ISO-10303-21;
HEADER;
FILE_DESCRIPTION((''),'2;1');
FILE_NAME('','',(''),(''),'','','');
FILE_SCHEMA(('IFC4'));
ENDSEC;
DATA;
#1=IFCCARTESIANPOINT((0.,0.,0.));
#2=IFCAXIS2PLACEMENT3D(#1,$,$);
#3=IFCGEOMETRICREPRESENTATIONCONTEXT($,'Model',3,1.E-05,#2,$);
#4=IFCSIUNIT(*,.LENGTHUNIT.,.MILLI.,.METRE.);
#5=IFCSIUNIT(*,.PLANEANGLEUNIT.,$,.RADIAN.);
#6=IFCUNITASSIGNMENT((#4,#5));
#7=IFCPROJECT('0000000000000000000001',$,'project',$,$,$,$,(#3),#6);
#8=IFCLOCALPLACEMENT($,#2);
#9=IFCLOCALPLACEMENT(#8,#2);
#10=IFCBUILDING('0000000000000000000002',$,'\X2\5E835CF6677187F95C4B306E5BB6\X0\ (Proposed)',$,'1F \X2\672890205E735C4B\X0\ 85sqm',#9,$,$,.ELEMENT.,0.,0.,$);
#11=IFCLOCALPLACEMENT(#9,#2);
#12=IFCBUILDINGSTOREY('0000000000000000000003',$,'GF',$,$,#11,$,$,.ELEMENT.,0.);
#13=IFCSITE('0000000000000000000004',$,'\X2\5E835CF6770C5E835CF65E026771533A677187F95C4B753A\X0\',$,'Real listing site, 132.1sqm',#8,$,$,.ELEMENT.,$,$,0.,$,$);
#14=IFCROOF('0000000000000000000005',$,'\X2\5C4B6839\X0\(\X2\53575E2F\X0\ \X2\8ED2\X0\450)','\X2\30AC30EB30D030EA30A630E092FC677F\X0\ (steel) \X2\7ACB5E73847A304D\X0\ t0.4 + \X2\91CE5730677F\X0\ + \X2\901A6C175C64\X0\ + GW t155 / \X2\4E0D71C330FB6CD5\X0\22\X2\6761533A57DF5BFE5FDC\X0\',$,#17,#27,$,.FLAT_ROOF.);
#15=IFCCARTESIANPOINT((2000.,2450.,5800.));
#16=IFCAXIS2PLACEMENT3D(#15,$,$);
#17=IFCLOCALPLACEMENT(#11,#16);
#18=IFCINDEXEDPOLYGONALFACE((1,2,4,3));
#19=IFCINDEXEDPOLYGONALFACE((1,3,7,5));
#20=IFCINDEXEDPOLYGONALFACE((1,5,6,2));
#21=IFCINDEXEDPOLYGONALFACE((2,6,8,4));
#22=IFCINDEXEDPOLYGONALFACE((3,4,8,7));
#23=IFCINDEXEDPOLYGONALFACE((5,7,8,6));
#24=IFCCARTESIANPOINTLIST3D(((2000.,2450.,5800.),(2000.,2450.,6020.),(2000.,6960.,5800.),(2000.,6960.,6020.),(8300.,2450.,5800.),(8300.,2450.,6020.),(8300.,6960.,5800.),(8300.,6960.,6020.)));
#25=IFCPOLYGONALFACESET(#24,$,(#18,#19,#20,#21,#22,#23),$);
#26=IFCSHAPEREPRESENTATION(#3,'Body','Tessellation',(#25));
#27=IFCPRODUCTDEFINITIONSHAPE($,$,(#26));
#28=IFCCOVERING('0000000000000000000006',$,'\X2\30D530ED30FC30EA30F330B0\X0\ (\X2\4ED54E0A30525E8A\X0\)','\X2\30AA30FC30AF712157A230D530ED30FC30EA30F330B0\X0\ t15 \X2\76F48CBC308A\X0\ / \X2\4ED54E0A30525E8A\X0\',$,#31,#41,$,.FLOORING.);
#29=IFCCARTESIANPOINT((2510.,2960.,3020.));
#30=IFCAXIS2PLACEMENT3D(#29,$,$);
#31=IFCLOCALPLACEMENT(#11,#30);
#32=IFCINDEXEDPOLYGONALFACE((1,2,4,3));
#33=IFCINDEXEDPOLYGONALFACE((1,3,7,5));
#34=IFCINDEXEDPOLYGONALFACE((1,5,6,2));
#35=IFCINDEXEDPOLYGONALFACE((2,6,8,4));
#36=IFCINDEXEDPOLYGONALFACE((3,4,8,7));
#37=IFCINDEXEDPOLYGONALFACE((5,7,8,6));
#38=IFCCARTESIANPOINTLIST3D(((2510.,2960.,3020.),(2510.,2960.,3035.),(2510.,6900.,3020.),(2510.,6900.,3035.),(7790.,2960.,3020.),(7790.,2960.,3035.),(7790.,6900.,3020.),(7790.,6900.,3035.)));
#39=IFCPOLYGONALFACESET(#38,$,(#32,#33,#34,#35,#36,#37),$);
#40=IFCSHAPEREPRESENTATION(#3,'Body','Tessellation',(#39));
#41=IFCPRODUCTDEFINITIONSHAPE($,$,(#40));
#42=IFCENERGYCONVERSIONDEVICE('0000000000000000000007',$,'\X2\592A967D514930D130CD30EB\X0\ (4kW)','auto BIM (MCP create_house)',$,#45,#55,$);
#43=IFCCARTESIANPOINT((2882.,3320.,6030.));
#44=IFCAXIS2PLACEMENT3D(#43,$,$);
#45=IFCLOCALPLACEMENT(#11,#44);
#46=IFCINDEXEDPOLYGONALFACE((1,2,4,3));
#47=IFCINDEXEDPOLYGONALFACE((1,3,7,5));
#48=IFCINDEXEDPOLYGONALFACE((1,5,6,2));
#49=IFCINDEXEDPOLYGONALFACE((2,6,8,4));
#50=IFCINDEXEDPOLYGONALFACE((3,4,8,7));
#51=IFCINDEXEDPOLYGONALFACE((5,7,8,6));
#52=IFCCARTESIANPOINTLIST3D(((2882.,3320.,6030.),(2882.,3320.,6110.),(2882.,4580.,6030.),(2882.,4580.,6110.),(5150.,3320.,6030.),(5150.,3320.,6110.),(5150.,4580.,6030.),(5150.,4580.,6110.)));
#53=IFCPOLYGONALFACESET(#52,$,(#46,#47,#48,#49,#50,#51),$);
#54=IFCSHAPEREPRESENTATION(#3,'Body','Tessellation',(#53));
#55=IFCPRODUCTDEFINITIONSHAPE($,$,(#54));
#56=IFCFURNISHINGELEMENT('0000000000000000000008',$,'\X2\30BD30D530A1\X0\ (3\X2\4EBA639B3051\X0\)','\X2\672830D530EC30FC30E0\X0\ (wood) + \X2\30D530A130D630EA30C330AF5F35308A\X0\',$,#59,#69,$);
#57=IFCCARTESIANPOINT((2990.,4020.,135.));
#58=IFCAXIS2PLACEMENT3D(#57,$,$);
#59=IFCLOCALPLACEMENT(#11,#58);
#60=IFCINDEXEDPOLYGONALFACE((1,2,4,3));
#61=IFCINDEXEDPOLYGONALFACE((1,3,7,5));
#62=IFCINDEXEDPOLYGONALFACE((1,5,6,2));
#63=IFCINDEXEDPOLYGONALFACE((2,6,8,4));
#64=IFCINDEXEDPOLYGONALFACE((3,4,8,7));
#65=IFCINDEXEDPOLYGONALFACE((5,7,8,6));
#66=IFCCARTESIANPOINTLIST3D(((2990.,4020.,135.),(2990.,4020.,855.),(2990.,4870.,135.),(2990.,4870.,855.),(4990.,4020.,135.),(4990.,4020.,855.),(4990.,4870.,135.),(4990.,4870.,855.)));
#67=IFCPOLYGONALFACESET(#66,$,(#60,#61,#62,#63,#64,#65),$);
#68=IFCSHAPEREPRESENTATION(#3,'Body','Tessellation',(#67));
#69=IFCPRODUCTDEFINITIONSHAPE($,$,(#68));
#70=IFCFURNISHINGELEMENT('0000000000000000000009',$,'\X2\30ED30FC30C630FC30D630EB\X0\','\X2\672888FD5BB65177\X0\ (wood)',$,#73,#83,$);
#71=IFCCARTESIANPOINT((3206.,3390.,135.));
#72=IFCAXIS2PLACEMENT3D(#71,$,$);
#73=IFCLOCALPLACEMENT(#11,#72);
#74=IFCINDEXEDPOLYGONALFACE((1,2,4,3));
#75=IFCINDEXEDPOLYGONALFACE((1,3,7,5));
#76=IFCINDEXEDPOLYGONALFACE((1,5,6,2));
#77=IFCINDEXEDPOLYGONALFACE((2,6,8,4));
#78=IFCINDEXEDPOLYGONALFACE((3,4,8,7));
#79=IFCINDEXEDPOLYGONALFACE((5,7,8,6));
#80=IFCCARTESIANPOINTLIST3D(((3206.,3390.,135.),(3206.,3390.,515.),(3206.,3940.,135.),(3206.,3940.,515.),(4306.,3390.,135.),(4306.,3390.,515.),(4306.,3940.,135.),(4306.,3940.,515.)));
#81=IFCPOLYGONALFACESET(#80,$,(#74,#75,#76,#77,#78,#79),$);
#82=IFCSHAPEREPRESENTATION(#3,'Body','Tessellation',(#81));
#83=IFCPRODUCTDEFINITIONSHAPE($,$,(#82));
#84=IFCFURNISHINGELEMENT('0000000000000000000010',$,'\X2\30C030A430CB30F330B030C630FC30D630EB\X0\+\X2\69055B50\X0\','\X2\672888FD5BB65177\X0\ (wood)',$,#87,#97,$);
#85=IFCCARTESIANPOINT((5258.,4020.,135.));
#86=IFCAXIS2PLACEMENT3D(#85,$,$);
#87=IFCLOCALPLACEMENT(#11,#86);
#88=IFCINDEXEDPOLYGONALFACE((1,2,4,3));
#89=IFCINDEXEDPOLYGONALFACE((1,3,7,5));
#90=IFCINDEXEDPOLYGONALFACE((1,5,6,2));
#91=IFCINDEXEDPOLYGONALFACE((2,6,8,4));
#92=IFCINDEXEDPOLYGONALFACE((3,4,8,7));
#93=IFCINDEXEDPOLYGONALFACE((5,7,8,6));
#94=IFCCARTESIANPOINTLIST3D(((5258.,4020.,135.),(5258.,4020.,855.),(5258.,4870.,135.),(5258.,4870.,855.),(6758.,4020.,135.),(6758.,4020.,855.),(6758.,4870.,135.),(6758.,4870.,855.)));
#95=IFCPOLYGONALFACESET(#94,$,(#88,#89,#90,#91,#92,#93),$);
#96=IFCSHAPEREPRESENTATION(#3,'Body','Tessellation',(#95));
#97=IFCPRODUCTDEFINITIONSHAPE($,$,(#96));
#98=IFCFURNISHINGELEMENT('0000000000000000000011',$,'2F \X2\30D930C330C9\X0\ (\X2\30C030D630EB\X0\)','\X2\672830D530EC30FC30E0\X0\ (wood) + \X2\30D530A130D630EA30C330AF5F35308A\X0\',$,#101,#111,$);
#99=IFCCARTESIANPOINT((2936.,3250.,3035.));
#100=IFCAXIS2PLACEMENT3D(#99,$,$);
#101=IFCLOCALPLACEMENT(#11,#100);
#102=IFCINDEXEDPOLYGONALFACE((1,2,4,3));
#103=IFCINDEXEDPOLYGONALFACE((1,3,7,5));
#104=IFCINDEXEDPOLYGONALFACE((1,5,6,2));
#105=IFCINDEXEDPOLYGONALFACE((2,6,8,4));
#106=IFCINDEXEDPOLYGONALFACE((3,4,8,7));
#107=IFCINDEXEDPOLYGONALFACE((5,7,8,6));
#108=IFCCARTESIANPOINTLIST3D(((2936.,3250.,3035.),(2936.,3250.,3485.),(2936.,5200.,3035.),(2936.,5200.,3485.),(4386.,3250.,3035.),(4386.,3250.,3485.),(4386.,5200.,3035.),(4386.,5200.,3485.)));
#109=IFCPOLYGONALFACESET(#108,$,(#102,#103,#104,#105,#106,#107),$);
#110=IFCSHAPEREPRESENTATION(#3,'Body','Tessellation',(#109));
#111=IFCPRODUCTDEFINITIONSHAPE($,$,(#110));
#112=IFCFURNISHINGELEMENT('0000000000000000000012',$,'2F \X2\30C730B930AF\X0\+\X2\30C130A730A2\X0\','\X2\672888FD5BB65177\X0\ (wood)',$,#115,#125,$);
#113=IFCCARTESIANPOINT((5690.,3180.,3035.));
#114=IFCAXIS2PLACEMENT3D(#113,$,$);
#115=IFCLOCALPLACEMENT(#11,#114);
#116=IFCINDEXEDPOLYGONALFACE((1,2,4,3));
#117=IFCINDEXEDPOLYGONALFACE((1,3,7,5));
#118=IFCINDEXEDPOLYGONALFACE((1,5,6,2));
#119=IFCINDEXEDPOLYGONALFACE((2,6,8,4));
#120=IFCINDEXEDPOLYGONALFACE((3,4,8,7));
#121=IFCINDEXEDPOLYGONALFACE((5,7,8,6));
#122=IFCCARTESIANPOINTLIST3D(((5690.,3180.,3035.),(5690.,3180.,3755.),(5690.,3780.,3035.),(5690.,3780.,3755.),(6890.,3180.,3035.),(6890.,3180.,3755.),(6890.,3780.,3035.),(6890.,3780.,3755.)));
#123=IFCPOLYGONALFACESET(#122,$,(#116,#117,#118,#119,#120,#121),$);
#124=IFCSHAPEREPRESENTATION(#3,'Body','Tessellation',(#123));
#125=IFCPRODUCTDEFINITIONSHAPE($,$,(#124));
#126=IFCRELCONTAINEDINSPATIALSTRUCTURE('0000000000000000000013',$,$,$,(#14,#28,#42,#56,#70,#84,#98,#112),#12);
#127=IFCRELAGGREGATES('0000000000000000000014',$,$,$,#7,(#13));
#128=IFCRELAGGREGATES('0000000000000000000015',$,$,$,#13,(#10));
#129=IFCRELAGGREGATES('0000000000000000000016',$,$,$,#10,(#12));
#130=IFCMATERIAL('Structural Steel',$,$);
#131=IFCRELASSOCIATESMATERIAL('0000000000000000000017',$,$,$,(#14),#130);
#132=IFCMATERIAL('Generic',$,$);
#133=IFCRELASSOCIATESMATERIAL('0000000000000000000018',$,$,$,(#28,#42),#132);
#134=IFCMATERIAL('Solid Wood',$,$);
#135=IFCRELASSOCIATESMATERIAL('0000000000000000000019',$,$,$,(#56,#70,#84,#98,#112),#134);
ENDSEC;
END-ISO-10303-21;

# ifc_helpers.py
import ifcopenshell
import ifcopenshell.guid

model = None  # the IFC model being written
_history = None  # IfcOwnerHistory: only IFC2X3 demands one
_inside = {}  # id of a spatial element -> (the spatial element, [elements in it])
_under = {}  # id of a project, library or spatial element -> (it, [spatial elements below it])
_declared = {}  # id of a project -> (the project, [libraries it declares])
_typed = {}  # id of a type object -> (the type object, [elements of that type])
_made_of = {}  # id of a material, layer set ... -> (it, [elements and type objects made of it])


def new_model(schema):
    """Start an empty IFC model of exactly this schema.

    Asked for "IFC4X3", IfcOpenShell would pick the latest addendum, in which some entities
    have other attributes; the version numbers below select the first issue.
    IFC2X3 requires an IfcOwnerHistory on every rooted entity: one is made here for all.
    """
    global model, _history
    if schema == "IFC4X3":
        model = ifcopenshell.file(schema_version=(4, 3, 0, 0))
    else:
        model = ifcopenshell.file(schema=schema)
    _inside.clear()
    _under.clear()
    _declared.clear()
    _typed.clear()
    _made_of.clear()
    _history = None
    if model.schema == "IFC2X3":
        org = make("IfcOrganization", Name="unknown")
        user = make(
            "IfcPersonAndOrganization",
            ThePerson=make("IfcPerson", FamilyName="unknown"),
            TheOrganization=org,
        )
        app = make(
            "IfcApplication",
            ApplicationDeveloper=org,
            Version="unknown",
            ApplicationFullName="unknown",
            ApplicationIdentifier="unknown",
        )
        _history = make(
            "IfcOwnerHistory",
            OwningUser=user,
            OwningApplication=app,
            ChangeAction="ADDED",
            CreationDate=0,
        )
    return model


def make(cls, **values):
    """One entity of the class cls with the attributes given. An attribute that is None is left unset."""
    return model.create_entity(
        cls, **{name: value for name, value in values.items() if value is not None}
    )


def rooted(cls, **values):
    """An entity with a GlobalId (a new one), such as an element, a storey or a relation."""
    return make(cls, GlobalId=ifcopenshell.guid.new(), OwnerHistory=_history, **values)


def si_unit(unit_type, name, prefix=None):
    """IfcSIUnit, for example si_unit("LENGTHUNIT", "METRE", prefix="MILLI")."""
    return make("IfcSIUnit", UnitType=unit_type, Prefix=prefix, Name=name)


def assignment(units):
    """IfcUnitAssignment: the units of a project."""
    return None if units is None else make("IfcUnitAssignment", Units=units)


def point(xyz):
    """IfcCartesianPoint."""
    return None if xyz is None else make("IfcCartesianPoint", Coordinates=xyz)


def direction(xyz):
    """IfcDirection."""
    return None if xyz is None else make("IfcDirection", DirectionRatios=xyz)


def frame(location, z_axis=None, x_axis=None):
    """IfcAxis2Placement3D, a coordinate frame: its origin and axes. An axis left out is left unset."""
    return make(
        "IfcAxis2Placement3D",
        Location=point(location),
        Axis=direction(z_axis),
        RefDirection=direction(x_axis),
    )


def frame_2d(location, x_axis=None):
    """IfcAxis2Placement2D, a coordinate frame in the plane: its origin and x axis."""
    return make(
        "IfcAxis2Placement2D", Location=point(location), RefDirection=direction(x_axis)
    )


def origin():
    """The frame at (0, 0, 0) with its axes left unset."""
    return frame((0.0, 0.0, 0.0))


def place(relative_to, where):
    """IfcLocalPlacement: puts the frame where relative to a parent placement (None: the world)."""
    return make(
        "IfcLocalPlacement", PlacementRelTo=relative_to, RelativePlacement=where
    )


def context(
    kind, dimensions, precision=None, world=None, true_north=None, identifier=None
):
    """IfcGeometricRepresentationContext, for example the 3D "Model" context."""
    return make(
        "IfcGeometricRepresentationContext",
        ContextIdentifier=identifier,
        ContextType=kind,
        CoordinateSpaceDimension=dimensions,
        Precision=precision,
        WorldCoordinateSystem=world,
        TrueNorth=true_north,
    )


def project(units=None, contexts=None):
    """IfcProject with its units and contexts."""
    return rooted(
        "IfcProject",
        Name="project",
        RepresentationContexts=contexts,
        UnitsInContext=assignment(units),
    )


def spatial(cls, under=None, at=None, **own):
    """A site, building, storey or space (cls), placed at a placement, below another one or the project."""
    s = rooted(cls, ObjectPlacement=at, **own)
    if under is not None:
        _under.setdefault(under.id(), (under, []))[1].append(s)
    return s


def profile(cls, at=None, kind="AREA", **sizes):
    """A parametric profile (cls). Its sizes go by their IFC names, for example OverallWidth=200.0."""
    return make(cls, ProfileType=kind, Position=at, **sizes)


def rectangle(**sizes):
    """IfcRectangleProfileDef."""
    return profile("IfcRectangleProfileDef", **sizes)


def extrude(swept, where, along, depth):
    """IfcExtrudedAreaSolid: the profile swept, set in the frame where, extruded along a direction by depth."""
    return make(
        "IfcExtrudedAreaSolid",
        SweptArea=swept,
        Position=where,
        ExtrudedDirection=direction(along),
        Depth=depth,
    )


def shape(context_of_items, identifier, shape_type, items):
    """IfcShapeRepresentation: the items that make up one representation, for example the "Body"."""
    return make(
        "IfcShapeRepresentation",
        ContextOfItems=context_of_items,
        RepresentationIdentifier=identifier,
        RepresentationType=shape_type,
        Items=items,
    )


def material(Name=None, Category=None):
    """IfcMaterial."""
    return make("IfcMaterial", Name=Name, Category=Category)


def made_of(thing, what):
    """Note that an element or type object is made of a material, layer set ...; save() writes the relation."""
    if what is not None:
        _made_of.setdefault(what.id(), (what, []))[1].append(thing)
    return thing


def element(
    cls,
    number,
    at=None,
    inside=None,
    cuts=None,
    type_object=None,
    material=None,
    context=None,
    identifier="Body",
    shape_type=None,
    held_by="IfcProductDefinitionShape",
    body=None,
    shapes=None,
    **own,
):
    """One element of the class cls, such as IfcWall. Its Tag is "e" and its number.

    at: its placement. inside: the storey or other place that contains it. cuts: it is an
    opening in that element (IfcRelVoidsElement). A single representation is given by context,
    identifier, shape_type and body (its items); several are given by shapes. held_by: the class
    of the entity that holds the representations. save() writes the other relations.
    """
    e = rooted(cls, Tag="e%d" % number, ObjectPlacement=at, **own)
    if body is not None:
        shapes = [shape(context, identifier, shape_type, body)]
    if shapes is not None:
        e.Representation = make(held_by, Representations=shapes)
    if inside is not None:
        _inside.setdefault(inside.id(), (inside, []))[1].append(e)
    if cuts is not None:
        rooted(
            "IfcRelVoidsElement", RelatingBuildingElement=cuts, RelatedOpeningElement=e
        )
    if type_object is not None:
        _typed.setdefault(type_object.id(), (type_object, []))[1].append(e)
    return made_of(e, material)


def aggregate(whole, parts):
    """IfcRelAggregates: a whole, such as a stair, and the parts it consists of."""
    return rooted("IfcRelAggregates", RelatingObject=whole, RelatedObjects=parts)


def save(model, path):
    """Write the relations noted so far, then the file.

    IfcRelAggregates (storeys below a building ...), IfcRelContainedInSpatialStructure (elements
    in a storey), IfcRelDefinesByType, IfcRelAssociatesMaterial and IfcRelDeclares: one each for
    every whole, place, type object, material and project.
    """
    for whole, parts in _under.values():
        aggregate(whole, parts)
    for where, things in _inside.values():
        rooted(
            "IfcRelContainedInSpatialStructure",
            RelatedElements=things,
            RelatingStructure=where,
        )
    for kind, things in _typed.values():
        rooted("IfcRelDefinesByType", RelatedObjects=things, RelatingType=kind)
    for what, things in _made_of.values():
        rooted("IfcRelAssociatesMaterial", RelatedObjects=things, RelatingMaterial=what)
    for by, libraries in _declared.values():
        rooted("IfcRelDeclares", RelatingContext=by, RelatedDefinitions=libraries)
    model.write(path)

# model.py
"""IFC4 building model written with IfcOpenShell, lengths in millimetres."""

from ifc_helpers import new_model, si_unit, frame, frame_2d, origin, place, context, project, spatial, rectangle, extrude, material, element, save


model = new_model("IFC4")

# Units and contexts
model_context = context("Model", 3, precision=1e-05, world=origin())
ifc_project = project(units=[si_unit("LENGTHUNIT", "METRE", prefix="MILLI"), si_unit("PLANEANGLEUNIT", "RADIAN")], contexts=[model_context])

# Site, building, storey
site_placement = place(None, origin())
site = spatial("IfcSite", under=ifc_project, at=site_placement, Name="広島県広島市東区東蟹屋町", ObjectType="Real listing site, 132.1sqm", CompositionType="ELEMENT", RefElevation=0.0)
building_placement = place(site_placement, origin())
building = spatial("IfcBuilding", under=site, at=building_placement, Name="広島東蟹屋の家 (Proposed)", ObjectType="1F 木造平屋 85sqm", CompositionType="ELEMENT", ElevationOfRefHeight=0.0, ElevationOfTerrain=0.0)
storey_placement = place(building_placement, origin())
storey = spatial("IfcBuildingStorey", under=building, at=storey_placement, Name="GF", CompositionType="ELEMENT", Elevation=0.0)

# Shared definitions
ifc_material_1 = material(Name="Solid Wood")

# Shared definitions
ifc_material_2 = material(Name="Generic")

# Roof
ifc_material_3 = material(Name="Structural Steel")
for number, where, name in (
    (1, (2000.0, 2450.0, 5800.0), "屋根(南帯 軒450)"),
):
    element("IfcRoof", number, at=place(storey_placement, frame(where)), inside=storey, material=ifc_material_3, Name=name, Description="ガルバリウム鋼板 (steel) 立平葺き t0.4 + 野地板 + 通気層 + GW t155 / 不燃・法22条区域対応", PredefinedType="FLAT_ROOF", context=model_context, shape_type="SweptSolid", body=[
        extrude(rectangle(XDim=6300.0, YDim=4510.0, at=frame_2d((3150.0, 2255.0))), frame((2000.0, 2450.0, 5800.0)), (0.0, 0.0, 1.0), 220.0),
    ])

# Covering
covering_placement = place(storey_placement, frame((2510.0, 2960.0, 3020.0)))
element("IfcCovering", 2, at=covering_placement, inside=storey, material=ifc_material_2, Name="フローリング (仕上げ床)", Description="オーク無垢フローリング t15 直貼り / 仕上げ床", PredefinedType="FLOORING", context=model_context, shape_type="SweptSolid", body=[
    extrude(rectangle(XDim=5280.0, YDim=3940.0, at=frame_2d((2640.0, 1970.0))), frame((2510.0, 2960.0, 3020.0)), (0.0, 0.0, 1.0), 15.0),
])

# Energy conversion device
energy_conversion_device_placement = place(storey_placement, frame((2882.0, 3320.0, 6030.0)))
element("IfcEnergyConversionDevice", 3, at=energy_conversion_device_placement, inside=storey, material=ifc_material_2, Name="太陽光パネル (4kW)", Description="auto BIM (MCP create_house)", context=model_context, shape_type="SweptSolid", body=[
    extrude(rectangle(XDim=2268.0, YDim=1260.0, at=frame_2d((1134.0, 630.0))), frame((2882.0, 3320.0, 6030.0)), (0.0, 0.0, 1.0), 80.0),
])

# Furnishing elements
furnishing_1_placement = place(storey_placement, frame((2990.0, 4020.0, 135.0)))
element("IfcFurnishingElement", 4, at=furnishing_1_placement, inside=storey, material=ifc_material_1, Name="ソファ (3人掛け)", Description="木フレーム (wood) + ファブリック張り", context=model_context, shape_type="SweptSolid", body=[
    extrude(rectangle(XDim=2000.0, YDim=850.0, at=frame_2d((1000.0, 425.0))), frame((2990.0, 4020.0, 135.0)), (0.0, 0.0, 1.0), 720.0),
])
furnishing_2_placement = place(storey_placement, frame((3206.0, 3390.0, 135.0)))
element("IfcFurnishingElement", 5, at=furnishing_2_placement, inside=storey, material=ifc_material_1, Name="ローテーブル", Description="木製家具 (wood)", context=model_context, shape_type="SweptSolid", body=[
    extrude(rectangle(XDim=1100.0, YDim=550.0, at=frame_2d((550.0, 275.0))), frame((3206.0, 3390.0, 135.0)), (0.0, 0.0, 1.0), 380.0),
])
furnishing_3_placement = place(storey_placement, frame((5258.0, 4020.0, 135.0)))
element("IfcFurnishingElement", 6, at=furnishing_3_placement, inside=storey, material=ifc_material_1, Name="ダイニングテーブル+椅子", Description="木製家具 (wood)", context=model_context, shape_type="SweptSolid", body=[
    extrude(rectangle(XDim=1500.0, YDim=850.0, at=frame_2d((750.0, 425.0))), frame((5258.0, 4020.0, 135.0)), (0.0, 0.0, 1.0), 720.0),
])
furnishing_4_placement = place(storey_placement, frame((2936.0, 3250.0, 3035.0)))
element("IfcFurnishingElement", 7, at=furnishing_4_placement, inside=storey, material=ifc_material_1, Name="2F ベッド (ダブル)", Description="木フレーム (wood) + ファブリック張り", context=model_context, shape_type="SweptSolid", body=[
    extrude(rectangle(XDim=1450.0, YDim=1950.0, at=frame_2d((725.0, 975.0))), frame((2936.0, 3250.0, 3035.0)), (0.0, 0.0, 1.0), 450.0),
])
furnishing_5_placement = place(storey_placement, frame((5690.0, 3180.0, 3035.0)))
element("IfcFurnishingElement", 8, at=furnishing_5_placement, inside=storey, material=ifc_material_1, Name="2F デスク+チェア", Description="木製家具 (wood)", context=model_context, shape_type="SweptSolid", body=[
    extrude(rectangle(XDim=1200.0, YDim=600.0, at=frame_2d((600.0, 300.0))), frame((5690.0, 3180.0, 3035.0)), (0.0, 0.0, 1.0), 720.0),
])

save(model, "model.ifc")
